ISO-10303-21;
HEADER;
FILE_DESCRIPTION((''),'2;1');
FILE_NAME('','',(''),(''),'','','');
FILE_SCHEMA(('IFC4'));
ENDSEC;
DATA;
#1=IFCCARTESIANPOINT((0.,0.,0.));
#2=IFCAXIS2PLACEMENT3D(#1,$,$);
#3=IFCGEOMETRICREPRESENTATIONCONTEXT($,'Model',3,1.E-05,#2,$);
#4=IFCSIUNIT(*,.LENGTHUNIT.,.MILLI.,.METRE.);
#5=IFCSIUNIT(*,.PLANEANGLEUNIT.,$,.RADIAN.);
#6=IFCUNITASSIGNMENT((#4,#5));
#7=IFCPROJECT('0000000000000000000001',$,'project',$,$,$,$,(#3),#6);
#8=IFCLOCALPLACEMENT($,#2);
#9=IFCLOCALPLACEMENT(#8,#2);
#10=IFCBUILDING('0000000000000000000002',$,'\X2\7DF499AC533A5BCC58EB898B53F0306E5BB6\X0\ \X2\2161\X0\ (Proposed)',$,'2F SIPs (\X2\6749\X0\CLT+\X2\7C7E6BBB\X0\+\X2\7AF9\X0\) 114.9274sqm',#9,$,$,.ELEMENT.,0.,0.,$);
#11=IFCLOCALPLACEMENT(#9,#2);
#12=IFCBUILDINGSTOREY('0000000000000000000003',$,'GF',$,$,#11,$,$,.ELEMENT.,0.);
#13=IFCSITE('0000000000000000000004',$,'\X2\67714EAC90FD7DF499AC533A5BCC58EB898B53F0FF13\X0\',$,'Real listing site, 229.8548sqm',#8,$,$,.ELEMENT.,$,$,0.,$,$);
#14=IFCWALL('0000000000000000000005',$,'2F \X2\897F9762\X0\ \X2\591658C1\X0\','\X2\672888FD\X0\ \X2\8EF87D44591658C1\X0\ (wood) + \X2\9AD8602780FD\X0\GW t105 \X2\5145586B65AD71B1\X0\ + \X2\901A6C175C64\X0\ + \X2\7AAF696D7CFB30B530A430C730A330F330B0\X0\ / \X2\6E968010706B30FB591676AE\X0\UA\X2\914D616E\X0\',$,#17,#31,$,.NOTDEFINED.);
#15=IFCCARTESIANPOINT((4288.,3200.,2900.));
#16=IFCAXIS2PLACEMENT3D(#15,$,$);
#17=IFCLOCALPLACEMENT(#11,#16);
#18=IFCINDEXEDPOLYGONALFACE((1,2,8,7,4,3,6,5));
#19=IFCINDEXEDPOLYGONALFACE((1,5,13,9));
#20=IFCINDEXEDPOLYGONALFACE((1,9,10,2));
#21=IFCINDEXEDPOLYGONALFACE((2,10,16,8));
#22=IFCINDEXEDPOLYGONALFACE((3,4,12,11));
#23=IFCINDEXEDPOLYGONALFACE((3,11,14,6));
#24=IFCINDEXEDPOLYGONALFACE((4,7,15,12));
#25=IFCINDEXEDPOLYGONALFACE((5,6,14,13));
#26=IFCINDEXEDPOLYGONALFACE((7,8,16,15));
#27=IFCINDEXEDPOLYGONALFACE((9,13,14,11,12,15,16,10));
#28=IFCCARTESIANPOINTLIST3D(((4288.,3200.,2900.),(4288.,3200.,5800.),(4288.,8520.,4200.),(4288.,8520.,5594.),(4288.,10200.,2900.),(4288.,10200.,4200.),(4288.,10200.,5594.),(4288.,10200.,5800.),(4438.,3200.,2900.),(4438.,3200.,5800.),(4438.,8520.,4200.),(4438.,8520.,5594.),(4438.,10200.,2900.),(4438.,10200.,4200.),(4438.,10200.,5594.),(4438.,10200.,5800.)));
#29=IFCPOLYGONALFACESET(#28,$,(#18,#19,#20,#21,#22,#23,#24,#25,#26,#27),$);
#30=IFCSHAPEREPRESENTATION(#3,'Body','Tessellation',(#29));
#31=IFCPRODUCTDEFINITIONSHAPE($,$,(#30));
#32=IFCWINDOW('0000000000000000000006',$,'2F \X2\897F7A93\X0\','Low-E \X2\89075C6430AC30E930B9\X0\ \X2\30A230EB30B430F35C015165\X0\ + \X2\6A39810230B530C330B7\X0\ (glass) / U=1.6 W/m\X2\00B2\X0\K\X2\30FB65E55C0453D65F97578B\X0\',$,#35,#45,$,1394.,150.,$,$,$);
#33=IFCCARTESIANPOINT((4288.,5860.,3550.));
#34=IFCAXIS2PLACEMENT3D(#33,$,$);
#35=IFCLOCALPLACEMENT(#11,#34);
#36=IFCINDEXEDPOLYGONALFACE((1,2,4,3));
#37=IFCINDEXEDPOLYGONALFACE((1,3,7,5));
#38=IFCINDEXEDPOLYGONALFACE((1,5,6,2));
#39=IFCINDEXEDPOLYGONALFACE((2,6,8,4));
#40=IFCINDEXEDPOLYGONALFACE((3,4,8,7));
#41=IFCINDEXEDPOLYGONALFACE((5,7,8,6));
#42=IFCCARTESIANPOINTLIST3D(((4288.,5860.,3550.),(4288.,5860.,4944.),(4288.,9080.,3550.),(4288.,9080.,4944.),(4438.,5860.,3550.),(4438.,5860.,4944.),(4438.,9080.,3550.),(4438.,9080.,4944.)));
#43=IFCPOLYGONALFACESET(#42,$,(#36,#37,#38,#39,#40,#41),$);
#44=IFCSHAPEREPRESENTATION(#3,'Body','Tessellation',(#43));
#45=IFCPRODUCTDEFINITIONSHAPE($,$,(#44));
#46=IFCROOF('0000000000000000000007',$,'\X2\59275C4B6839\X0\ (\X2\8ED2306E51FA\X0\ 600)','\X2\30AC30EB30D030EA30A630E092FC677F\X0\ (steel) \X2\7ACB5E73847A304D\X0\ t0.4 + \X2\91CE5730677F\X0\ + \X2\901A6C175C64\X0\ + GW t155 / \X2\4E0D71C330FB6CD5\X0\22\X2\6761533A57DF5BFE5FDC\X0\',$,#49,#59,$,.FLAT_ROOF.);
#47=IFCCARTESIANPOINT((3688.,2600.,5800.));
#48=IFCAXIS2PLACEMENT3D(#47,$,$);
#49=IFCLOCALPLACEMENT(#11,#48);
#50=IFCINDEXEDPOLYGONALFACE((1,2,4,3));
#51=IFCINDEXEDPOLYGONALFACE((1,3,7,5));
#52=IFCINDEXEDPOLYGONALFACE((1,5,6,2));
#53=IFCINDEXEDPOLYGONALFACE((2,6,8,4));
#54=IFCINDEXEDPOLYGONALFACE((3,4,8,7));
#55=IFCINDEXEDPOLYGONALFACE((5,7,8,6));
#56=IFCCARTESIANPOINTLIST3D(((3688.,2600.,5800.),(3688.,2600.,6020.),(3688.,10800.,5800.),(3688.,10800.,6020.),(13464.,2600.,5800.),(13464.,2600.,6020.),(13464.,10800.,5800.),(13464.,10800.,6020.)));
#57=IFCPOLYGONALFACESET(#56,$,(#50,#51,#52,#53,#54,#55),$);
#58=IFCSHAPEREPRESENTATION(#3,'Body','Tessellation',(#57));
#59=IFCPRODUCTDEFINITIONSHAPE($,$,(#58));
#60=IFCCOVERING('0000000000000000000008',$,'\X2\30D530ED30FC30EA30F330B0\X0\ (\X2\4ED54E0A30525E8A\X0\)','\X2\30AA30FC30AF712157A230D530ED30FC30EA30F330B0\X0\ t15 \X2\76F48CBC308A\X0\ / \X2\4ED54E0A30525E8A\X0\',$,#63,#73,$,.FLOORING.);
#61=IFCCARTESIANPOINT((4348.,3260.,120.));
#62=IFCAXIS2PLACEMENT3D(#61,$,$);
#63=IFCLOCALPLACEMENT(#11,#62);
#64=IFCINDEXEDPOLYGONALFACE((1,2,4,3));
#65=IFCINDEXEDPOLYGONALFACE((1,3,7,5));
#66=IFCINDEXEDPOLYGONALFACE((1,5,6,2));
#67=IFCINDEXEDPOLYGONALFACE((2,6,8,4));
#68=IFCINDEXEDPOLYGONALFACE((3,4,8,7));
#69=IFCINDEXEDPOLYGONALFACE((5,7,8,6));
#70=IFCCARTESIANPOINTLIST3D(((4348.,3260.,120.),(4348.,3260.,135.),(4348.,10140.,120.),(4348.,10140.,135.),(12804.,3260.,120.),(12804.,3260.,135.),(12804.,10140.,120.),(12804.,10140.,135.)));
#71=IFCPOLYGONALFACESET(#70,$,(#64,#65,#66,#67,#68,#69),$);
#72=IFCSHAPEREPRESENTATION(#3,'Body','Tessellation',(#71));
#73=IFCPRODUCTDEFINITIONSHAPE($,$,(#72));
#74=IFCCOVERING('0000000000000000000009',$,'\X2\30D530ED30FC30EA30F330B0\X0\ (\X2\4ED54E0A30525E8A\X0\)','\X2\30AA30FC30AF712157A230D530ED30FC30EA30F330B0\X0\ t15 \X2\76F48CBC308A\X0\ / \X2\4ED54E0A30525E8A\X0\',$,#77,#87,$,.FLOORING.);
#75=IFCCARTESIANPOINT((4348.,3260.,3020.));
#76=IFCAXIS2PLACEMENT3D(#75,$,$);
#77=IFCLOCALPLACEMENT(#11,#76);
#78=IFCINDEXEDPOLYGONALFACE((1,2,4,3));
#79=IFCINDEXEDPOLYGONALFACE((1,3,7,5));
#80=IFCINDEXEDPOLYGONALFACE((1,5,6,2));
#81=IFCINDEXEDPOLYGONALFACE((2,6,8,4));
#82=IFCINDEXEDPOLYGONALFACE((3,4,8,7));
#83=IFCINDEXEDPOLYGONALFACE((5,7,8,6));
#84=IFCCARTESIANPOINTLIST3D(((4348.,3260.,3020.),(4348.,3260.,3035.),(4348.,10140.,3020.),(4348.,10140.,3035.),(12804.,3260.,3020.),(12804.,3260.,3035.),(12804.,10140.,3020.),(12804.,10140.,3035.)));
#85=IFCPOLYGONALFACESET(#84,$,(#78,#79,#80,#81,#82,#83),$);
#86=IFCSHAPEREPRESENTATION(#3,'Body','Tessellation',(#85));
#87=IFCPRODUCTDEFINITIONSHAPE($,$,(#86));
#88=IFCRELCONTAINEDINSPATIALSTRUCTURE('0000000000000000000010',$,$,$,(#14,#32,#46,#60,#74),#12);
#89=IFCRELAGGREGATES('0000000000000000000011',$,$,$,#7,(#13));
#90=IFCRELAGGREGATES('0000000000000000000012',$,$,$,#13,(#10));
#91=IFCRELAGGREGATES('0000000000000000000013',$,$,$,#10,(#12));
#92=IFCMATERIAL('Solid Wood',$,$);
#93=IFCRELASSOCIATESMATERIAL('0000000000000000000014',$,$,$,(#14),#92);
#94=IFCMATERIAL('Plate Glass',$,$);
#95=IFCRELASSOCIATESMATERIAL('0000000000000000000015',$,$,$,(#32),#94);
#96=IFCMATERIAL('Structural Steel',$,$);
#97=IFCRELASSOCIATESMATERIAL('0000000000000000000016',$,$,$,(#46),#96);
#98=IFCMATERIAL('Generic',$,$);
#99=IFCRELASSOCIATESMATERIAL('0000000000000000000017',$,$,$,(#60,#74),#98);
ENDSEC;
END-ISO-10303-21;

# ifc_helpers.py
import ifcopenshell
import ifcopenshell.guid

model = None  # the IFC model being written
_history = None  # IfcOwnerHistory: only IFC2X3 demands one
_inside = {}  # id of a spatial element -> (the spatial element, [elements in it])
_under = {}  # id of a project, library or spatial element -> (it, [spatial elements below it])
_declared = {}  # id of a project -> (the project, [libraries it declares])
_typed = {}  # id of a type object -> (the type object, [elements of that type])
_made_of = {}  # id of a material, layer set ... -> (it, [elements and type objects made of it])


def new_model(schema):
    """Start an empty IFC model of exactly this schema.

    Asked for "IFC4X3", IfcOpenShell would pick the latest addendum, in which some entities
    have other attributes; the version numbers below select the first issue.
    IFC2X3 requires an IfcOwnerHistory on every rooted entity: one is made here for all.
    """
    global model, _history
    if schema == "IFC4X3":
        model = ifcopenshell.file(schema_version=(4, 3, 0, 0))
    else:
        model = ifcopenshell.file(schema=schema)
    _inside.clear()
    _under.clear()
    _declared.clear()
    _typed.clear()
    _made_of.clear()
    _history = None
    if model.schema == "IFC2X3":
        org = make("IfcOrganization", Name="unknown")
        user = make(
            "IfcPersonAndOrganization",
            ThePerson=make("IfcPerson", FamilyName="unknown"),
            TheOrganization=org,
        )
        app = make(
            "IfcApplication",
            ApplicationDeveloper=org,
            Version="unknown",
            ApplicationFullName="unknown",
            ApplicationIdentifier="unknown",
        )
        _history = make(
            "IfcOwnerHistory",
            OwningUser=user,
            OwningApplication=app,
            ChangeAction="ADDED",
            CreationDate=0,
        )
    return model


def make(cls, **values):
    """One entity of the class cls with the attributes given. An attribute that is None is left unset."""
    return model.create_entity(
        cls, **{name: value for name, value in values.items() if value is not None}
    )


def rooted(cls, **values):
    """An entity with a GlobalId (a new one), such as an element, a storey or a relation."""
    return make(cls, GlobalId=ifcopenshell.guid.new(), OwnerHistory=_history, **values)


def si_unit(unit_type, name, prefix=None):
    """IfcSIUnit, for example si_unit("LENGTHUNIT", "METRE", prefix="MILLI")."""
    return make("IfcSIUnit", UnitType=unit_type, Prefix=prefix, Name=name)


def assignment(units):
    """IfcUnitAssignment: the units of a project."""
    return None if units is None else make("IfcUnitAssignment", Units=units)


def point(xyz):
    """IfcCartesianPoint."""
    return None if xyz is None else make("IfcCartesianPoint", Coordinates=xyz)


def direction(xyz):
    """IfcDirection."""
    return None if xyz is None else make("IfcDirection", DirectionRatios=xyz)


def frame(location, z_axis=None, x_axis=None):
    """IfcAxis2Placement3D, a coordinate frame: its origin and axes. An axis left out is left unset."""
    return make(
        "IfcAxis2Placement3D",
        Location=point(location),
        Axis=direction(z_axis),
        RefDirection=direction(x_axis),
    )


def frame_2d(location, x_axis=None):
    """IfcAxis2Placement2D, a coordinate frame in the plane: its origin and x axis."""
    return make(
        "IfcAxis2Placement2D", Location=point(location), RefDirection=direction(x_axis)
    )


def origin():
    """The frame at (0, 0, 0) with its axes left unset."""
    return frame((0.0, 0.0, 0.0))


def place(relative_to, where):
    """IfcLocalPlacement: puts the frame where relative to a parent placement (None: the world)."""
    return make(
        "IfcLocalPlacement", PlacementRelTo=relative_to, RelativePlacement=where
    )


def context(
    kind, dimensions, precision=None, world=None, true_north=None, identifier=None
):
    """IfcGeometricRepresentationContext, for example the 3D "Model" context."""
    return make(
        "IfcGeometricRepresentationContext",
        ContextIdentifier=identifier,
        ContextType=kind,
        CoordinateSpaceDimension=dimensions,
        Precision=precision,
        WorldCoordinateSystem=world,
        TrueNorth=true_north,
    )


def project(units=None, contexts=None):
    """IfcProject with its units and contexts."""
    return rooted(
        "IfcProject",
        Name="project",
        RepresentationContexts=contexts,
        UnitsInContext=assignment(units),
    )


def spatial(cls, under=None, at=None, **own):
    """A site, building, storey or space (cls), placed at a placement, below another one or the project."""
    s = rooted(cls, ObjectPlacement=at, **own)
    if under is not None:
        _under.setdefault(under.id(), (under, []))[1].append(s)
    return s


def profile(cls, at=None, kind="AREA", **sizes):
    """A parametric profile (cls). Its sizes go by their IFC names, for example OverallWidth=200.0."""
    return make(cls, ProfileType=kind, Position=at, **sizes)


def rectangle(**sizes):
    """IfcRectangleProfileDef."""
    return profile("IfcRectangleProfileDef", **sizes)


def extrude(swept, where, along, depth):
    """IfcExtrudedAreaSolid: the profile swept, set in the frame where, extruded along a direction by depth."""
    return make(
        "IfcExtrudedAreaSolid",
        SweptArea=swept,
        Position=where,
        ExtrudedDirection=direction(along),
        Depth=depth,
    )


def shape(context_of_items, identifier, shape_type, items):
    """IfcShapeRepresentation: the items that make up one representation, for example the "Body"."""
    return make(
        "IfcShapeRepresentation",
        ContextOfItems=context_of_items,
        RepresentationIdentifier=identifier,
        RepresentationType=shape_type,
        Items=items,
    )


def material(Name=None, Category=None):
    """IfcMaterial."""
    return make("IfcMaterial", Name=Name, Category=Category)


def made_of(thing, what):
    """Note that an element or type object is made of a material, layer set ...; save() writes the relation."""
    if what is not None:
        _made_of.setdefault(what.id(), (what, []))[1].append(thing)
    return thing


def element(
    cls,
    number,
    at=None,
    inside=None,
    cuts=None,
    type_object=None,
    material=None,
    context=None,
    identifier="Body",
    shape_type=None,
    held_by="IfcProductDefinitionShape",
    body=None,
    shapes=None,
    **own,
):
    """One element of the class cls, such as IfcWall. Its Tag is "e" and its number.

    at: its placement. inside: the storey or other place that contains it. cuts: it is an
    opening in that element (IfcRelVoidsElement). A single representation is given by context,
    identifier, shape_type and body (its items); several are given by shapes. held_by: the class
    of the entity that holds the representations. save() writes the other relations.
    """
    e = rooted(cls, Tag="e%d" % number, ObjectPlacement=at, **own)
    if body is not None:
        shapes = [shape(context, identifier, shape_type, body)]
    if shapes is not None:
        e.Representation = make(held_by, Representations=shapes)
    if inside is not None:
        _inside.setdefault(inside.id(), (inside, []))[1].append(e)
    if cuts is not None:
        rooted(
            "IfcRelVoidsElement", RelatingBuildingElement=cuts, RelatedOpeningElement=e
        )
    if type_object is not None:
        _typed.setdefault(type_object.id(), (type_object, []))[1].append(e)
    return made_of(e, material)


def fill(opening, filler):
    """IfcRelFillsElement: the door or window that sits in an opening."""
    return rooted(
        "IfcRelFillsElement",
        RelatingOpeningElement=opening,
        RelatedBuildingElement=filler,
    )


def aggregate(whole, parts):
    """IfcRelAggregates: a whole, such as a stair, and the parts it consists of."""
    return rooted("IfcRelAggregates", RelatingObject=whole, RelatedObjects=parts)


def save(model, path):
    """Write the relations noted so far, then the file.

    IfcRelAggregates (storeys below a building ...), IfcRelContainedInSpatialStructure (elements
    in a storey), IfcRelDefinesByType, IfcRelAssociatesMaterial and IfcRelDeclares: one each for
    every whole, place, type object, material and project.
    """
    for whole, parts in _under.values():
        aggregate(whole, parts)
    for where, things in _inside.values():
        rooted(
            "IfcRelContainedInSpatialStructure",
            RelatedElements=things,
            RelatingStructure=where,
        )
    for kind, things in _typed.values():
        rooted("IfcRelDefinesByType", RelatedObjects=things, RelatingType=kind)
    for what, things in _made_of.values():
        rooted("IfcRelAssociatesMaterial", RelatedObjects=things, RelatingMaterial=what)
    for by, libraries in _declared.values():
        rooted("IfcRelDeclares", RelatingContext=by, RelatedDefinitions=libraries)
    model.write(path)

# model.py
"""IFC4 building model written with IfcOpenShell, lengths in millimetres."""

from ifc_helpers import new_model, si_unit, frame, frame_2d, origin, place, context, project, spatial, rectangle, extrude, material, element, fill, save


model = new_model("IFC4")

# Units and contexts
model_context = context("Model", 3, precision=1e-05, world=origin())
ifc_project = project(units=[si_unit("LENGTHUNIT", "METRE", prefix="MILLI"), si_unit("PLANEANGLEUNIT", "RADIAN")], contexts=[model_context])

# Site, building, storey
site_placement = place(None, origin())
site = spatial("IfcSite", under=ifc_project, at=site_placement, Name="東京都練馬区富士見台３", ObjectType="Real listing site, 229.8548sqm", CompositionType="ELEMENT", RefElevation=0.0)
building_placement = place(site_placement, origin())
building = spatial("IfcBuilding", under=site, at=building_placement, Name="練馬区富士見台の家 Ⅱ (Proposed)", ObjectType="2F SIPs (杉CLT+籾殻+竹) 114.9274sqm", CompositionType="ELEMENT", ElevationOfRefHeight=0.0, ElevationOfTerrain=0.0)
storey_placement = place(building_placement, origin())
storey = spatial("IfcBuildingStorey", under=building, at=storey_placement, Name="GF", CompositionType="ELEMENT", Elevation=0.0)

# Shared definitions
ifc_material_1 = material(Name="Solid Wood")

# Shared definitions
ifc_material_2 = material(Name="Plate Glass")

# Wall, opening, window
wall_1_placement = place(storey_placement, frame((4288.0, 3200.0, 2900.0)))
wall_1 = element("IfcWall", 1, at=wall_1_placement, inside=storey, material=ifc_material_1, Name="2F 西面 外壁", Description="木製 軸組外壁 (wood) + 高性能GW t105 充填断熱 + 通気層 + 窯業系サイディング / 準耐火・外皮UA配慮", PredefinedType="NOTDEFINED", context=model_context, shape_type="SweptSolid", body=[
    extrude(rectangle(XDim=150.0, YDim=7000.0, at=frame_2d((75.0, 3500.0))), frame((4288.0, 3200.0, 2900.0)), (0.0, 0.0, 1.0), 2900.0),
])
opening_1_placement = place(storey_placement, frame((4288.0, 5860.0, 3550.0)))
opening_1 = element("IfcOpeningElement", 2, at=opening_1_placement, cuts=wall_1, PredefinedType="NOTDEFINED", context=model_context, shape_type="SweptSolid", body=[
    extrude(rectangle(XDim=150.0, YDim=3220.0, at=frame_2d((75.0, 1610.0))), frame((4288.0, 5860.0, 3550.0)), (0.0, 0.0, 1.0), 1394.0),
])
window_1_placement = place(storey_placement, frame((4288.0, 5860.0, 3550.0)))
window_1 = element("IfcWindow", 3, at=window_1_placement, inside=storey, material=ifc_material_2, Name="2F 西窓", Description="Low-E 複層ガラス アルゴン封入 + 樹脂サッシ (glass) / U=1.6 W/m²K・日射取得型", OverallHeight=1394.0, OverallWidth=150.0, context=model_context, shape_type="SweptSolid", body=[
    extrude(rectangle(XDim=150.0, YDim=3220.0, at=frame_2d((75.0, 1610.0))), frame((4288.0, 5860.0, 3550.0)), (0.0, 0.0, 1.0), 1394.0),
])
fill(opening_1, window_1)

# Roof
ifc_material_3 = material(Name="Structural Steel")
roof_placement = place(storey_placement, frame((3688.0, 2600.0, 5800.0)))
element("IfcRoof", 4, at=roof_placement, inside=storey, material=ifc_material_3, Name="大屋根 (軒の出 600)", Description="ガルバリウム鋼板 (steel) 立平葺き t0.4 + 野地板 + 通気層 + GW t155 / 不燃・法22条区域対応", PredefinedType="FLAT_ROOF", context=model_context, shape_type="SweptSolid", body=[
    extrude(rectangle(XDim=9776.0, YDim=8200.0, at=frame_2d((4888.0, 4100.0))), frame((3688.0, 2600.0, 5800.0)), (0.0, 0.0, 1.0), 220.0),
])

# Coverings
ifc_material_4 = material(Name="Generic")
covering_1_placement = place(storey_placement, frame((4348.0, 3260.0, 120.0)))
element("IfcCovering", 5, at=covering_1_placement, inside=storey, material=ifc_material_4, Name="フローリング (仕上げ床)", Description="オーク無垢フローリング t15 直貼り / 仕上げ床", PredefinedType="FLOORING", context=model_context, shape_type="SweptSolid", body=[
    extrude(rectangle(XDim=8456.0, YDim=6880.0, at=frame_2d((4228.0, 3440.0))), frame((4348.0, 3260.0, 120.0)), (0.0, 0.0, 1.0), 15.0),
])
covering_2_placement = place(storey_placement, frame((4348.0, 3260.0, 3020.0)))
element("IfcCovering", 6, at=covering_2_placement, inside=storey, material=ifc_material_4, Name="フローリング (仕上げ床)", Description="オーク無垢フローリング t15 直貼り / 仕上げ床", PredefinedType="FLOORING", context=model_context, shape_type="SweptSolid", body=[
    extrude(rectangle(XDim=8456.0, YDim=6880.0, at=frame_2d((4228.0, 3440.0))), frame((4348.0, 3260.0, 3020.0)), (0.0, 0.0, 1.0), 15.0),
])

save(model, "model.ifc")
